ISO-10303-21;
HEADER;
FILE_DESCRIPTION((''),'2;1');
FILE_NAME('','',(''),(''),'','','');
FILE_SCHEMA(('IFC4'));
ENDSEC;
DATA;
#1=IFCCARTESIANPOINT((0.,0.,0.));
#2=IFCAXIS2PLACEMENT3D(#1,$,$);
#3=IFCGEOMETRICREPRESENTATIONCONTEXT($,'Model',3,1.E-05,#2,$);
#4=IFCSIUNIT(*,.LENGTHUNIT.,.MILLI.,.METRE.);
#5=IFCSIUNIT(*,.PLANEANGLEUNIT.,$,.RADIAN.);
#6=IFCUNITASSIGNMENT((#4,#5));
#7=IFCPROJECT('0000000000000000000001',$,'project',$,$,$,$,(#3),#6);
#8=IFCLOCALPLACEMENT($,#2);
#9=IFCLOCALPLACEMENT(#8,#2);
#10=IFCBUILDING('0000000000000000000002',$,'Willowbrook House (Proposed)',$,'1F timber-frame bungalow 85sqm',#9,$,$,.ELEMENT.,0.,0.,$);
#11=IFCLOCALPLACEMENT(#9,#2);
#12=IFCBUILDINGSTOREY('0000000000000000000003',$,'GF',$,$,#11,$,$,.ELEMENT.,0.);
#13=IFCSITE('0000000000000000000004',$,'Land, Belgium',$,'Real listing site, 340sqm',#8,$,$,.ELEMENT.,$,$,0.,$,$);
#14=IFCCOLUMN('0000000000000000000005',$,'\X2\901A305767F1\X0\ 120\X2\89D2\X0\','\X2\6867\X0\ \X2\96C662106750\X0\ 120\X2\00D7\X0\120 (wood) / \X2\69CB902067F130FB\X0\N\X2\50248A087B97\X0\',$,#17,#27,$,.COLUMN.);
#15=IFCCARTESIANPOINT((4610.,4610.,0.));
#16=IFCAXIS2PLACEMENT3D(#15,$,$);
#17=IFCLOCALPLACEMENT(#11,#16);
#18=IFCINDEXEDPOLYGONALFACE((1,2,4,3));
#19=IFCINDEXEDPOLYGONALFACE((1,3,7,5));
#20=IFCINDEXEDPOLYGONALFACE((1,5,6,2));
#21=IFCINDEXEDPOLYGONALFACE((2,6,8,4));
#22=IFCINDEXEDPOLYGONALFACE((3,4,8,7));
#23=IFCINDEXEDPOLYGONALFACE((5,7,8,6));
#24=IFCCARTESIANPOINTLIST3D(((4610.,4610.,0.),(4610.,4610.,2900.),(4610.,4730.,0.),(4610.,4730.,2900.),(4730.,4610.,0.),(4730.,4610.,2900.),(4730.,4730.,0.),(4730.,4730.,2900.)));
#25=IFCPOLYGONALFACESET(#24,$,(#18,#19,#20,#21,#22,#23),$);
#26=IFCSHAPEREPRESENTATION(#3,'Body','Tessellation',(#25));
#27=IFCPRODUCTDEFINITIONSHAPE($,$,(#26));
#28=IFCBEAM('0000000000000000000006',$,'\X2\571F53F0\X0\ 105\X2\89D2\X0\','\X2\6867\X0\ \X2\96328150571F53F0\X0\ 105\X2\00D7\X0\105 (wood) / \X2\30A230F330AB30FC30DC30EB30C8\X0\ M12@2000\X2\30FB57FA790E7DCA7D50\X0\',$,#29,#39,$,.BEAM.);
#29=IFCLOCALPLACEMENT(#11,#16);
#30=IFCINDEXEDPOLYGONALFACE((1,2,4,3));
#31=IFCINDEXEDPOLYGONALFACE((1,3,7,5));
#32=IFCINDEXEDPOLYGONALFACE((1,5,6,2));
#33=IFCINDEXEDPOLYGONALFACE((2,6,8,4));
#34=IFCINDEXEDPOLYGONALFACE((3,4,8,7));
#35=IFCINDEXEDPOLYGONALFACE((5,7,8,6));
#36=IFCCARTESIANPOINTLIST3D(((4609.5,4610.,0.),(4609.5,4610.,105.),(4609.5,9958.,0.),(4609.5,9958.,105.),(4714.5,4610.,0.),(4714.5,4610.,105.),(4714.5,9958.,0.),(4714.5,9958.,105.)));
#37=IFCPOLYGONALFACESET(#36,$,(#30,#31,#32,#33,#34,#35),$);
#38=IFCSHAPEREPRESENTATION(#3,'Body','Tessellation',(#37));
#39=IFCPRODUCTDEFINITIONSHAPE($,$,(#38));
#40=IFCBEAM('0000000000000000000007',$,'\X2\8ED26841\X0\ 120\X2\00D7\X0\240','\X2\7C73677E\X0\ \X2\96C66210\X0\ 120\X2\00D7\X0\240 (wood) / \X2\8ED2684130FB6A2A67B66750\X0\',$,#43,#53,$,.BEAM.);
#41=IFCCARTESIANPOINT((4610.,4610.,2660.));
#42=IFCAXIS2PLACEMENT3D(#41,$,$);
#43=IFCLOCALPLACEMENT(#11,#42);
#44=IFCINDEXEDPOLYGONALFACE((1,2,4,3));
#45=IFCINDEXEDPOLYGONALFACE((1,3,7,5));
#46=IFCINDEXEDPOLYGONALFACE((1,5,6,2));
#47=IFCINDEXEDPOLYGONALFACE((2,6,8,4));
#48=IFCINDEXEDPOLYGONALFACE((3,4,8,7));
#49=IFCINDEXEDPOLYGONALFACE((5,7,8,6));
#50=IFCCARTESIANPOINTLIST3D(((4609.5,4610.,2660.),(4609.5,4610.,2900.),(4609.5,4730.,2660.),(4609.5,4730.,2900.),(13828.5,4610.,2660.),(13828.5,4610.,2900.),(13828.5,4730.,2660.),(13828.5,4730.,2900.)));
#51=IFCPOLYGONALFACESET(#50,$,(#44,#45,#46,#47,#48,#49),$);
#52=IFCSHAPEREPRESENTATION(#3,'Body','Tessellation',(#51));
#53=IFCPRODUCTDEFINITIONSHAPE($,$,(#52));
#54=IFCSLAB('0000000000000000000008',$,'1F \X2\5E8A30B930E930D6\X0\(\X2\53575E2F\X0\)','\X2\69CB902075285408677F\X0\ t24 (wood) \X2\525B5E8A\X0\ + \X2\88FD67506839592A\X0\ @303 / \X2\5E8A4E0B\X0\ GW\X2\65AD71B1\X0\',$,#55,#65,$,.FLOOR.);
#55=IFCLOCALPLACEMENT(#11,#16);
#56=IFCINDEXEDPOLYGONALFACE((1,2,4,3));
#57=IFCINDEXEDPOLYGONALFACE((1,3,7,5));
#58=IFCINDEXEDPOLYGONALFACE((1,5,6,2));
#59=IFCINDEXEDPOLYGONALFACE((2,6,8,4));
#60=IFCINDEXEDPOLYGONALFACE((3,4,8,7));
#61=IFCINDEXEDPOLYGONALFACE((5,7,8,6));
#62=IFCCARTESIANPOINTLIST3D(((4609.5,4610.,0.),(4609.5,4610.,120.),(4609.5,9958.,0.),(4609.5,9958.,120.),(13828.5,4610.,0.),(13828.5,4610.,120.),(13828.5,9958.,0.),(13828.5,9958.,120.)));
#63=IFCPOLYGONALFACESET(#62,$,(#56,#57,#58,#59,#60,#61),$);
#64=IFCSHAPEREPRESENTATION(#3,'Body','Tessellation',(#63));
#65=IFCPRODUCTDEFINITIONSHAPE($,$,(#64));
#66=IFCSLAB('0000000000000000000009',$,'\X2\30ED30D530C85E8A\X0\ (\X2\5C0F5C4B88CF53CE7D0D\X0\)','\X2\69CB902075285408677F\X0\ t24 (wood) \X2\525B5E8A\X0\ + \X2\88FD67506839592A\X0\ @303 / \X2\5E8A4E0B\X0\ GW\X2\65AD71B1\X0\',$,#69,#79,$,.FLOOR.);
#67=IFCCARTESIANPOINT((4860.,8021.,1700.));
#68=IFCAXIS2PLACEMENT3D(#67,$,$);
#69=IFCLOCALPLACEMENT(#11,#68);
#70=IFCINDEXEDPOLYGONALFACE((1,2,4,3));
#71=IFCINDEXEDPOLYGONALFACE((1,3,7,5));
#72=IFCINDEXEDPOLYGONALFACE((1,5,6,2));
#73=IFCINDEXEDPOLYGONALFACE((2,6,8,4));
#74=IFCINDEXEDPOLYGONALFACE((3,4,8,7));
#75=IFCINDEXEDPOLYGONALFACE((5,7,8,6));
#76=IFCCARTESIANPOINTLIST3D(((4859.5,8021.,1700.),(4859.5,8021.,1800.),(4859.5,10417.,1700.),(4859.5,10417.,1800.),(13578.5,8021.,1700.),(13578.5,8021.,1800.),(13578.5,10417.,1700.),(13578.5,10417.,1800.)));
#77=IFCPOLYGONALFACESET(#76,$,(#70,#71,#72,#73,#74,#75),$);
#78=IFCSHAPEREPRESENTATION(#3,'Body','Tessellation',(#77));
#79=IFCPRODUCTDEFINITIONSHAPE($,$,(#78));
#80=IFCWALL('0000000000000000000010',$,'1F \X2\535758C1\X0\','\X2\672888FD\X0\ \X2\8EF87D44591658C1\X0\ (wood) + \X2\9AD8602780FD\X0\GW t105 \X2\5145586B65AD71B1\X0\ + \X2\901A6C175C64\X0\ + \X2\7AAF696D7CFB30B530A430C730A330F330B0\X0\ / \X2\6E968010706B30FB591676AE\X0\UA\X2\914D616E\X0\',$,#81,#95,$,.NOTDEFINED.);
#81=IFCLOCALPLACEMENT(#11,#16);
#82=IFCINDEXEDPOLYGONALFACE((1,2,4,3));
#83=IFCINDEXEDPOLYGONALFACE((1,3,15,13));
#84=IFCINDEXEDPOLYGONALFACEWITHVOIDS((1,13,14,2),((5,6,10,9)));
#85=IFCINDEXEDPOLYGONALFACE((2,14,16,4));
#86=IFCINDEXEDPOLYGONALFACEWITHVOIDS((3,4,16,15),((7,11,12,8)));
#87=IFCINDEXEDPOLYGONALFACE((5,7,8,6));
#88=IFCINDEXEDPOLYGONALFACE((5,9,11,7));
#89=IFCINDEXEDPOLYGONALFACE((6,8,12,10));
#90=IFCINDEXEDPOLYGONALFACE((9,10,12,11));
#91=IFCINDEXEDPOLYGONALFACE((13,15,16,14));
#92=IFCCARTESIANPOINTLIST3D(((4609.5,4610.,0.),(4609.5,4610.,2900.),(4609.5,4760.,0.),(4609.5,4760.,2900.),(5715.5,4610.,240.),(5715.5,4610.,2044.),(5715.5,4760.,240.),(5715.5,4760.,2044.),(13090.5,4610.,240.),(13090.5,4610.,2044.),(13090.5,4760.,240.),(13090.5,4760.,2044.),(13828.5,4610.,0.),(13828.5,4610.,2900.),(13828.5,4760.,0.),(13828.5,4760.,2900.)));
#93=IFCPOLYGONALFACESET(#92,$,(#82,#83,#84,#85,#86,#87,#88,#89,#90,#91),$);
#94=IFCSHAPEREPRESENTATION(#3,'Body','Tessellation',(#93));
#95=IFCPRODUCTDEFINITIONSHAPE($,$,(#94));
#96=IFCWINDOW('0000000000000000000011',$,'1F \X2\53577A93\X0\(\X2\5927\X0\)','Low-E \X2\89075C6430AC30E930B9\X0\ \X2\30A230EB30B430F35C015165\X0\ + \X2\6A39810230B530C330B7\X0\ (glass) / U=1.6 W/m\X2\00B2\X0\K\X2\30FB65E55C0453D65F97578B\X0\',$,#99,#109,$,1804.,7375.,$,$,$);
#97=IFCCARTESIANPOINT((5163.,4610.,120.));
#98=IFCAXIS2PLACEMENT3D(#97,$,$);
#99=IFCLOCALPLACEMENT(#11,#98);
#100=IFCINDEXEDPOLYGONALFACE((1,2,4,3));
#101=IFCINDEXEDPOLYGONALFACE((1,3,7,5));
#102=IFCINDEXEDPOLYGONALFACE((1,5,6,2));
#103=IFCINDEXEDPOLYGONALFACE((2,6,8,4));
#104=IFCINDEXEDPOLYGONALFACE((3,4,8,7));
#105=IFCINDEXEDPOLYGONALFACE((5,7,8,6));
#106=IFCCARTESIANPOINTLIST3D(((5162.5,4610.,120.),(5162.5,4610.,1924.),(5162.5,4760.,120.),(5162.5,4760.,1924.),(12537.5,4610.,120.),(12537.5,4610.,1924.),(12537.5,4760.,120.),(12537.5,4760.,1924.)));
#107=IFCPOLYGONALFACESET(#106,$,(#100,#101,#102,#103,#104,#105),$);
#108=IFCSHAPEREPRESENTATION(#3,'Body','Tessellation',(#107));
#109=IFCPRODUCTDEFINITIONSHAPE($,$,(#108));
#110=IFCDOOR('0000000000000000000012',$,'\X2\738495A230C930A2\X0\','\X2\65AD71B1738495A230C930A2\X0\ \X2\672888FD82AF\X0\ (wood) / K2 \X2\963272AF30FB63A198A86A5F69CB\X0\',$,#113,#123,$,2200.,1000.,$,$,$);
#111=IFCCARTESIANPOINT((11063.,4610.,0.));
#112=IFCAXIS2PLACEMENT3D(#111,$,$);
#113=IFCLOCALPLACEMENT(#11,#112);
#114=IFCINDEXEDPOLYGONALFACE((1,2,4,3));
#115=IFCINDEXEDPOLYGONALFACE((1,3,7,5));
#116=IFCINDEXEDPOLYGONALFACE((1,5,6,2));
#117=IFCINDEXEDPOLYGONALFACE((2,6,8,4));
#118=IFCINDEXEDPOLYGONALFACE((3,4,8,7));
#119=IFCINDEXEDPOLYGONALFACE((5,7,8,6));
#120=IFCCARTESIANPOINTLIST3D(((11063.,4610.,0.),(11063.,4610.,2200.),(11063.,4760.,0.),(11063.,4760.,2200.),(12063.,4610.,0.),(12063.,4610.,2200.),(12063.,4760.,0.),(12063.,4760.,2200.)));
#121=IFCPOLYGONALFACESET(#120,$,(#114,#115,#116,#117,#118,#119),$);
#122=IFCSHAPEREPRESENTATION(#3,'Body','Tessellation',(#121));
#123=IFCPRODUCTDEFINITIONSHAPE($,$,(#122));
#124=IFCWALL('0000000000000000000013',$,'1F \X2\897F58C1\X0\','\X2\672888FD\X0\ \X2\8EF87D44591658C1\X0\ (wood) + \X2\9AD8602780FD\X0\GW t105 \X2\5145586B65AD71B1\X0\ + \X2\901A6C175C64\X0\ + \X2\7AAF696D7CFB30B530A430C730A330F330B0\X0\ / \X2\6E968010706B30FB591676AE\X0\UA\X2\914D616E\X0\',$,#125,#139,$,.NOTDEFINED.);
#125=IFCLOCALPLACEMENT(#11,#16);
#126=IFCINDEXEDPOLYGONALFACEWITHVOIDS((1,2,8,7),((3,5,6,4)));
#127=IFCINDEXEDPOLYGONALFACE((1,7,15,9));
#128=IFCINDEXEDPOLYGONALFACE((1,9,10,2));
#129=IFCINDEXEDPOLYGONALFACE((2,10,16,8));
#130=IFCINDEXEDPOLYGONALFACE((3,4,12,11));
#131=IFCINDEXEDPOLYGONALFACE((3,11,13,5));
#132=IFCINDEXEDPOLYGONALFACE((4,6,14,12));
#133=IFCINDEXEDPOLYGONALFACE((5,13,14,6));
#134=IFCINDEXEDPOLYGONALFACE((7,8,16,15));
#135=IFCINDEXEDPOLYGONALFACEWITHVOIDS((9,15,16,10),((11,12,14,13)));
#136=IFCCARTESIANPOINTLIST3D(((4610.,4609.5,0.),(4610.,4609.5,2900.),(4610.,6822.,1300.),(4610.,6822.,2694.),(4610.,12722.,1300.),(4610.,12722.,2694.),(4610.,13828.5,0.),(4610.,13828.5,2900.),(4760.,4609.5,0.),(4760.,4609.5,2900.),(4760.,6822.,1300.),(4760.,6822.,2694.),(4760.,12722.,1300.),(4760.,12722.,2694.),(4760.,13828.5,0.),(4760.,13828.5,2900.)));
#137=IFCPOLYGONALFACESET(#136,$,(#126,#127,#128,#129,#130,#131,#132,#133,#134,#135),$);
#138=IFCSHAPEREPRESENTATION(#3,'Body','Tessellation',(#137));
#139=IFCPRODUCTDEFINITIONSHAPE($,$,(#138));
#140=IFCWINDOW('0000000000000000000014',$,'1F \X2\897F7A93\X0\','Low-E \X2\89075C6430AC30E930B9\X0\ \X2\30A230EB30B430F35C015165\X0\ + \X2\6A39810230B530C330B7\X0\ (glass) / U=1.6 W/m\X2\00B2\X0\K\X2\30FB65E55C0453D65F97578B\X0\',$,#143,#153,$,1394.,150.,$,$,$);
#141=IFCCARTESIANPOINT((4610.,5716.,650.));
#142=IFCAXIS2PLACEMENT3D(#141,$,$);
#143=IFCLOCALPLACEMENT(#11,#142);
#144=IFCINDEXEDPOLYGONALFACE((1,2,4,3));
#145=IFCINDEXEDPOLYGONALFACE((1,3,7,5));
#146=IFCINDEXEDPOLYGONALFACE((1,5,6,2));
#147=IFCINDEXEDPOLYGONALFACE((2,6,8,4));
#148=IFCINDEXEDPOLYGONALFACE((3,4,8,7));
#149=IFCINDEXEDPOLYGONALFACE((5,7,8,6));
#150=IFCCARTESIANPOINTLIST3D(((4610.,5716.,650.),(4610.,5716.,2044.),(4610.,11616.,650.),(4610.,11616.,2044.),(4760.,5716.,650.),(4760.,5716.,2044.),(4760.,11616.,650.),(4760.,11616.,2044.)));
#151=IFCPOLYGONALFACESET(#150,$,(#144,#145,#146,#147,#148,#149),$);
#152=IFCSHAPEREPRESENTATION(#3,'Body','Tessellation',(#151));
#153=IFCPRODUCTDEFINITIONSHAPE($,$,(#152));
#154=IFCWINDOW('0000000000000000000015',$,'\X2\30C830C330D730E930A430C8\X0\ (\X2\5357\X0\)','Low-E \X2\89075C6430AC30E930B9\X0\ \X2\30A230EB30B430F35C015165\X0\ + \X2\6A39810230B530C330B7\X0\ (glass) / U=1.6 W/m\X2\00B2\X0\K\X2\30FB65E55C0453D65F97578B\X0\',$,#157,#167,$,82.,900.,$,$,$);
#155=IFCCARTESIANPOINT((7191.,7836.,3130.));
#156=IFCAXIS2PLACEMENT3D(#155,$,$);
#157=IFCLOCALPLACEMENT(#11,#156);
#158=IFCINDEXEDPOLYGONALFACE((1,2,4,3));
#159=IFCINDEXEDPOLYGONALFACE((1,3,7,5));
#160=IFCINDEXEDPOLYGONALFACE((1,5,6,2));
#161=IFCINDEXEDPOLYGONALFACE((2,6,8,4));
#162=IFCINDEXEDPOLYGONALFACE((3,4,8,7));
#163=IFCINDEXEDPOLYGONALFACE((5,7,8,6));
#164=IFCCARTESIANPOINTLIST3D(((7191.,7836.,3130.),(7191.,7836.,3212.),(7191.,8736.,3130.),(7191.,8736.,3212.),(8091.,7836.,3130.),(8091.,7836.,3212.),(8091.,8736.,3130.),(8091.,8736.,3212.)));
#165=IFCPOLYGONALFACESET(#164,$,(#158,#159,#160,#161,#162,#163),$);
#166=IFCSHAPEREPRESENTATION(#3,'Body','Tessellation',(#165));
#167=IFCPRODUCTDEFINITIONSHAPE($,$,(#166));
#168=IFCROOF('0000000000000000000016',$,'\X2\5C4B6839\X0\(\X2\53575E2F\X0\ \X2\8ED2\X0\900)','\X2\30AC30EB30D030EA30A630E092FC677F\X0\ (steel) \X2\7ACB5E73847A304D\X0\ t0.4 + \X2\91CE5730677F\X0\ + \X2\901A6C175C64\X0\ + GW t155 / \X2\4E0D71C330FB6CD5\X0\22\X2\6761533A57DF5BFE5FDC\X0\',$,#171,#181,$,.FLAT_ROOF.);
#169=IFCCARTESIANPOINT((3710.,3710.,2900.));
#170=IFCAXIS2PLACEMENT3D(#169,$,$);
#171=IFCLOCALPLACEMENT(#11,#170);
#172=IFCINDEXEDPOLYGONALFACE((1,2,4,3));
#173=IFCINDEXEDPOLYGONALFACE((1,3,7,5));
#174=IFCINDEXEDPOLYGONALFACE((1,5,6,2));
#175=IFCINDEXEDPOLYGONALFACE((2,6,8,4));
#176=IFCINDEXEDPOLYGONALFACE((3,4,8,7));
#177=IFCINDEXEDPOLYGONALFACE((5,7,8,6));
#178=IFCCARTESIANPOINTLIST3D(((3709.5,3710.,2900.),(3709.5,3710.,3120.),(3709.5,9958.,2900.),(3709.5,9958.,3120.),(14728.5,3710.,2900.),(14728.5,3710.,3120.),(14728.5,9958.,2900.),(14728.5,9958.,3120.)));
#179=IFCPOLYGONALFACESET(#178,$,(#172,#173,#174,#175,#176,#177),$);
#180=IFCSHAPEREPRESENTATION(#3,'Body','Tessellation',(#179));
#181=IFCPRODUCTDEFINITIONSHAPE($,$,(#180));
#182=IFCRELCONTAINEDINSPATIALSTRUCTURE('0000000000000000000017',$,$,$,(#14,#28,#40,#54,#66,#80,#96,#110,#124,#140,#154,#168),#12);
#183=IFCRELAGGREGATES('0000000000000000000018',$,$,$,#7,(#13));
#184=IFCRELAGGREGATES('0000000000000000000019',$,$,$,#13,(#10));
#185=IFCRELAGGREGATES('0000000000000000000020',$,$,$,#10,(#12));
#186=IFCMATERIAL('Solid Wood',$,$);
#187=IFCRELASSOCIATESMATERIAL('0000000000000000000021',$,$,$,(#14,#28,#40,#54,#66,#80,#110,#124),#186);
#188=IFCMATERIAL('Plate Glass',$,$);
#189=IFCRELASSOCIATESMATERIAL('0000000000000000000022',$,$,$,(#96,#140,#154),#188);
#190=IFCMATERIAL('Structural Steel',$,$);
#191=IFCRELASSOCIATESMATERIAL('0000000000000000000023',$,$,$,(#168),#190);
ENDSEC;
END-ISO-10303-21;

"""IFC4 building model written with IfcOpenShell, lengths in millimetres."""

from ifc_helpers import new_model, si_unit, frame, frame_2d, origin, place, context, project, spatial, rectangle, extrude, material, element, fill, save


model = new_model("IFC4")

# Units and contexts
model_context = context("Model", 3, precision=1e-05, world=origin())
ifc_project = project(units=[si_unit("LENGTHUNIT", "METRE", prefix="MILLI"), si_unit("PLANEANGLEUNIT", "RADIAN")], contexts=[model_context])

# Site, building, storey
site_placement = place(None, origin())
site = spatial("IfcSite", under=ifc_project, at=site_placement, Name="Land, Belgium", ObjectType="Real listing site, 340sqm", CompositionType="ELEMENT", RefElevation=0.0)
building_placement = place(site_placement, origin())
building = spatial("IfcBuilding", under=site, at=building_placement, Name="Willowbrook House (Proposed)", ObjectType="1F timber-frame bungalow 85sqm", CompositionType="ELEMENT", ElevationOfRefHeight=0.0, ElevationOfTerrain=0.0)
storey_placement = place(building_placement, origin())
storey = spatial("IfcBuildingStorey", under=building, at=storey_placement, Name="GF", CompositionType="ELEMENT", Elevation=0.0)

# Column
ifc_material_1 = material(Name="Solid Wood")
column_1_placement = place(storey_placement, frame((4610.0, 4610.0, 0.0)))
element("IfcColumn", 1, at=column_1_placement, inside=storey, material=ifc_material_1, Name="通し柱 120角", Description="桧 集成材 120×120 (wood) / 構造柱・N値計算", PredefinedType="COLUMN", context=model_context, shape_type="SweptSolid", body=[
    extrude(rectangle(XDim=120.0, YDim=120.0, at=frame_2d((60.0, 60.0))), frame((4610.0, 4610.0, 0.0)), (0.0, 0.0, 1.0), 2900.0),
])

# Beams
beam_1_placement = place(storey_placement, frame((4610.0, 4610.0, 0.0)))
element("IfcBeam", 2, at=beam_1_placement, inside=storey, material=ifc_material_1, Name="土台 105角", Description="桧 防腐土台 105×105 (wood) / アンカーボルト M12@2000・基礎緊結", PredefinedType="BEAM", context=model_context, shape_type="SweptSolid", body=[
    extrude(rectangle(XDim=105.0, YDim=5348.0, at=frame_2d((52.0, 2674.0))), frame((4610.0, 4610.0, 0.0)), (0.0, 0.0, 1.0), 105.0),
])
beam_2_placement = place(storey_placement, frame((4610.0, 4610.0, 2660.0)))
element("IfcBeam", 3, at=beam_2_placement, inside=storey, material=ifc_material_1, Name="軒桁 120×240", Description="米松 集成 120×240 (wood) / 軒桁・横架材", PredefinedType="BEAM", context=model_context, shape_type="SweptSolid", body=[
    extrude(rectangle(XDim=9219.0, YDim=120.0, at=frame_2d((4609.0, 60.0))), frame((4610.0, 4610.0, 2660.0)), (0.0, 0.0, 1.0), 240.0),
])

# Slabs
slab_1_placement = place(storey_placement, frame((4610.0, 4610.0, 0.0)))
element("IfcSlab", 4, at=slab_1_placement, inside=storey, material=ifc_material_1, Name="1F 床スラブ(南帯)", Description="構造用合板 t24 (wood) 剛床 + 製材根太 @303 / 床下 GW断熱", PredefinedType="FLOOR", context=model_context, shape_type="SweptSolid", body=[
    extrude(rectangle(XDim=9219.0, YDim=5348.0, at=frame_2d((4609.0, 2674.0))), frame((4610.0, 4610.0, 0.0)), (0.0, 0.0, 1.0), 120.0),
])
slab_2_placement = place(storey_placement, frame((4860.0, 8021.0, 1700.0)))
element("IfcSlab", 5, at=slab_2_placement, inside=storey, material=ifc_material_1, Name="ロフト床 (小屋裏収納)", Description="構造用合板 t24 (wood) 剛床 + 製材根太 @303 / 床下 GW断熱", PredefinedType="FLOOR", context=model_context, shape_type="SweptSolid", body=[
    extrude(rectangle(XDim=8719.0, YDim=2396.0, at=frame_2d((4359.0, 1198.0))), frame((4860.0, 8021.0, 1700.0)), (0.0, 0.0, 1.0), 100.0),
])

# Wall, openings, window, door
wall_1_placement = place(storey_placement, frame((4610.0, 4610.0, 0.0)))
wall_1 = element("IfcWall", 6, at=wall_1_placement, inside=storey, material=ifc_material_1, Name="1F 南壁", Description="木製 軸組外壁 (wood) + 高性能GW t105 充填断熱 + 通気層 + 窯業系サイディング / 準耐火・外皮UA配慮", PredefinedType="NOTDEFINED", context=model_context, shape_type="SweptSolid", body=[
    extrude(rectangle(XDim=9219.0, YDim=150.0, at=frame_2d((4609.0, 75.0))), frame((4610.0, 4610.0, 0.0)), (0.0, 0.0, 1.0), 2900.0),
])
opening_1_placement = place(storey_placement, frame((5163.0, 4610.0, 120.0)))
opening_1 = element("IfcOpeningElement", 7, at=opening_1_placement, cuts=wall_1, PredefinedType="NOTDEFINED", context=model_context, shape_type="SweptSolid", body=[
    extrude(rectangle(XDim=7375.0, YDim=150.0, at=frame_2d((3687.0, 75.0))), frame((5163.0, 4610.0, 120.0)), (0.0, 0.0, 1.0), 1804.0),
])
opening_2_placement = place(storey_placement, frame((11063.0, 4610.0, 0.0)))
opening_2 = element("IfcOpeningElement", 8, at=opening_2_placement, cuts=wall_1, PredefinedType="NOTDEFINED", context=model_context, shape_type="SweptSolid", body=[
    extrude(rectangle(XDim=1000.0, YDim=150.0, at=frame_2d((500.0, 75.0))), frame((11063.0, 4610.0, 0.0)), (0.0, 0.0, 1.0), 2200.0),
])
ifc_material_2 = material(Name="Plate Glass")
window_1_placement = place(storey_placement, frame((5163.0, 4610.0, 120.0)))
window_1 = element("IfcWindow", 9, at=window_1_placement, inside=storey, material=ifc_material_2, Name="1F 南窓(大)", Description="Low-E 複層ガラス アルゴン封入 + 樹脂サッシ (glass) / U=1.6 W/m²K・日射取得型", OverallHeight=1804.0, OverallWidth=7375.0, context=model_context, shape_type="SweptSolid", body=[
    extrude(rectangle(XDim=7375.0, YDim=150.0, at=frame_2d((3687.0, 75.0))), frame((5163.0, 4610.0, 120.0)), (0.0, 0.0, 1.0), 1804.0),
])
fill(opening_1, window_1)
door_1_placement = place(storey_placement, frame((11063.0, 4610.0, 0.0)))
door_1 = element("IfcDoor", 10, at=door_1_placement, inside=storey, material=ifc_material_1, Name="玄関ドア", Description="断熱玄関ドア 木製芯 (wood) / K2 防犯・採風機構", OverallHeight=2200.0, OverallWidth=1000.0, context=model_context, shape_type="SweptSolid", body=[
    extrude(rectangle(XDim=1000.0, YDim=150.0, at=frame_2d((500.0, 75.0))), frame((11063.0, 4610.0, 0.0)), (0.0, 0.0, 1.0), 2200.0),
])
fill(opening_2, door_1)

# Wall, opening, window
wall_2_placement = place(storey_placement, frame((4610.0, 4610.0, 0.0)))
wall_2 = element("IfcWall", 11, at=wall_2_placement, inside=storey, material=ifc_material_1, Name="1F 西壁", Description="木製 軸組外壁 (wood) + 高性能GW t105 充填断熱 + 通気層 + 窯業系サイディング / 準耐火・外皮UA配慮", PredefinedType="NOTDEFINED", context=model_context, shape_type="SweptSolid", body=[
    extrude(rectangle(XDim=150.0, YDim=9219.0, at=frame_2d((75.0, 4609.0))), frame((4610.0, 4610.0, 0.0)), (0.0, 0.0, 1.0), 2900.0),
])
opening_3_placement = place(storey_placement, frame((4610.0, 5716.0, 650.0)))
opening_3 = element("IfcOpeningElement", 12, at=opening_3_placement, cuts=wall_2, PredefinedType="NOTDEFINED", context=model_context, shape_type="SweptSolid", body=[
    extrude(rectangle(XDim=150.0, YDim=5900.0, at=frame_2d((75.0, 2950.0))), frame((4610.0, 5716.0, 650.0)), (0.0, 0.0, 1.0), 1394.0),
])
window_2_placement = place(storey_placement, frame((4610.0, 5716.0, 650.0)))
window_2 = element("IfcWindow", 13, at=window_2_placement, inside=storey, material=ifc_material_2, Name="1F 西窓", Description="Low-E 複層ガラス アルゴン封入 + 樹脂サッシ (glass) / U=1.6 W/m²K・日射取得型", OverallHeight=1394.0, OverallWidth=150.0, context=model_context, shape_type="SweptSolid", body=[
    extrude(rectangle(XDim=150.0, YDim=5900.0, at=frame_2d((75.0, 2950.0))), frame((4610.0, 5716.0, 650.0)), (0.0, 0.0, 1.0), 1394.0),
])
fill(opening_3, window_2)

# Window
window_3_placement = place(storey_placement, frame((7191.0, 7836.0, 3130.0)))
element("IfcWindow", 14, at=window_3_placement, inside=storey, material=ifc_material_2, Name="トップライト (南)", Description="Low-E 複層ガラス アルゴン封入 + 樹脂サッシ (glass) / U=1.6 W/m²K・日射取得型", OverallHeight=82.0, OverallWidth=900.0, context=model_context, shape_type="SweptSolid", body=[
    extrude(rectangle(XDim=900.0, YDim=900.0, at=frame_2d((450.0, 450.0))), frame((7191.0, 7836.0, 3130.0)), (0.0, 0.0, 1.0), 82.0),
])

# Roof
ifc_material_3 = material(Name="Structural Steel")
roof_placement = place(storey_placement, frame((3710.0, 3710.0, 2900.0)))
element("IfcRoof", 15, at=roof_placement, inside=storey, material=ifc_material_3, Name="屋根(南帯 軒900)", Description="ガルバリウム鋼板 (steel) 立平葺き t0.4 + 野地板 + 通気層 + GW t155 / 不燃・法22条区域対応", PredefinedType="FLAT_ROOF", context=model_context, shape_type="SweptSolid", body=[
    extrude(rectangle(XDim=11019.0, YDim=6248.0, at=frame_2d((5509.0, 3124.0))), frame((3710.0, 3710.0, 2900.0)), (0.0, 0.0, 1.0), 220.0),
])

save(model, "model.ifc")
